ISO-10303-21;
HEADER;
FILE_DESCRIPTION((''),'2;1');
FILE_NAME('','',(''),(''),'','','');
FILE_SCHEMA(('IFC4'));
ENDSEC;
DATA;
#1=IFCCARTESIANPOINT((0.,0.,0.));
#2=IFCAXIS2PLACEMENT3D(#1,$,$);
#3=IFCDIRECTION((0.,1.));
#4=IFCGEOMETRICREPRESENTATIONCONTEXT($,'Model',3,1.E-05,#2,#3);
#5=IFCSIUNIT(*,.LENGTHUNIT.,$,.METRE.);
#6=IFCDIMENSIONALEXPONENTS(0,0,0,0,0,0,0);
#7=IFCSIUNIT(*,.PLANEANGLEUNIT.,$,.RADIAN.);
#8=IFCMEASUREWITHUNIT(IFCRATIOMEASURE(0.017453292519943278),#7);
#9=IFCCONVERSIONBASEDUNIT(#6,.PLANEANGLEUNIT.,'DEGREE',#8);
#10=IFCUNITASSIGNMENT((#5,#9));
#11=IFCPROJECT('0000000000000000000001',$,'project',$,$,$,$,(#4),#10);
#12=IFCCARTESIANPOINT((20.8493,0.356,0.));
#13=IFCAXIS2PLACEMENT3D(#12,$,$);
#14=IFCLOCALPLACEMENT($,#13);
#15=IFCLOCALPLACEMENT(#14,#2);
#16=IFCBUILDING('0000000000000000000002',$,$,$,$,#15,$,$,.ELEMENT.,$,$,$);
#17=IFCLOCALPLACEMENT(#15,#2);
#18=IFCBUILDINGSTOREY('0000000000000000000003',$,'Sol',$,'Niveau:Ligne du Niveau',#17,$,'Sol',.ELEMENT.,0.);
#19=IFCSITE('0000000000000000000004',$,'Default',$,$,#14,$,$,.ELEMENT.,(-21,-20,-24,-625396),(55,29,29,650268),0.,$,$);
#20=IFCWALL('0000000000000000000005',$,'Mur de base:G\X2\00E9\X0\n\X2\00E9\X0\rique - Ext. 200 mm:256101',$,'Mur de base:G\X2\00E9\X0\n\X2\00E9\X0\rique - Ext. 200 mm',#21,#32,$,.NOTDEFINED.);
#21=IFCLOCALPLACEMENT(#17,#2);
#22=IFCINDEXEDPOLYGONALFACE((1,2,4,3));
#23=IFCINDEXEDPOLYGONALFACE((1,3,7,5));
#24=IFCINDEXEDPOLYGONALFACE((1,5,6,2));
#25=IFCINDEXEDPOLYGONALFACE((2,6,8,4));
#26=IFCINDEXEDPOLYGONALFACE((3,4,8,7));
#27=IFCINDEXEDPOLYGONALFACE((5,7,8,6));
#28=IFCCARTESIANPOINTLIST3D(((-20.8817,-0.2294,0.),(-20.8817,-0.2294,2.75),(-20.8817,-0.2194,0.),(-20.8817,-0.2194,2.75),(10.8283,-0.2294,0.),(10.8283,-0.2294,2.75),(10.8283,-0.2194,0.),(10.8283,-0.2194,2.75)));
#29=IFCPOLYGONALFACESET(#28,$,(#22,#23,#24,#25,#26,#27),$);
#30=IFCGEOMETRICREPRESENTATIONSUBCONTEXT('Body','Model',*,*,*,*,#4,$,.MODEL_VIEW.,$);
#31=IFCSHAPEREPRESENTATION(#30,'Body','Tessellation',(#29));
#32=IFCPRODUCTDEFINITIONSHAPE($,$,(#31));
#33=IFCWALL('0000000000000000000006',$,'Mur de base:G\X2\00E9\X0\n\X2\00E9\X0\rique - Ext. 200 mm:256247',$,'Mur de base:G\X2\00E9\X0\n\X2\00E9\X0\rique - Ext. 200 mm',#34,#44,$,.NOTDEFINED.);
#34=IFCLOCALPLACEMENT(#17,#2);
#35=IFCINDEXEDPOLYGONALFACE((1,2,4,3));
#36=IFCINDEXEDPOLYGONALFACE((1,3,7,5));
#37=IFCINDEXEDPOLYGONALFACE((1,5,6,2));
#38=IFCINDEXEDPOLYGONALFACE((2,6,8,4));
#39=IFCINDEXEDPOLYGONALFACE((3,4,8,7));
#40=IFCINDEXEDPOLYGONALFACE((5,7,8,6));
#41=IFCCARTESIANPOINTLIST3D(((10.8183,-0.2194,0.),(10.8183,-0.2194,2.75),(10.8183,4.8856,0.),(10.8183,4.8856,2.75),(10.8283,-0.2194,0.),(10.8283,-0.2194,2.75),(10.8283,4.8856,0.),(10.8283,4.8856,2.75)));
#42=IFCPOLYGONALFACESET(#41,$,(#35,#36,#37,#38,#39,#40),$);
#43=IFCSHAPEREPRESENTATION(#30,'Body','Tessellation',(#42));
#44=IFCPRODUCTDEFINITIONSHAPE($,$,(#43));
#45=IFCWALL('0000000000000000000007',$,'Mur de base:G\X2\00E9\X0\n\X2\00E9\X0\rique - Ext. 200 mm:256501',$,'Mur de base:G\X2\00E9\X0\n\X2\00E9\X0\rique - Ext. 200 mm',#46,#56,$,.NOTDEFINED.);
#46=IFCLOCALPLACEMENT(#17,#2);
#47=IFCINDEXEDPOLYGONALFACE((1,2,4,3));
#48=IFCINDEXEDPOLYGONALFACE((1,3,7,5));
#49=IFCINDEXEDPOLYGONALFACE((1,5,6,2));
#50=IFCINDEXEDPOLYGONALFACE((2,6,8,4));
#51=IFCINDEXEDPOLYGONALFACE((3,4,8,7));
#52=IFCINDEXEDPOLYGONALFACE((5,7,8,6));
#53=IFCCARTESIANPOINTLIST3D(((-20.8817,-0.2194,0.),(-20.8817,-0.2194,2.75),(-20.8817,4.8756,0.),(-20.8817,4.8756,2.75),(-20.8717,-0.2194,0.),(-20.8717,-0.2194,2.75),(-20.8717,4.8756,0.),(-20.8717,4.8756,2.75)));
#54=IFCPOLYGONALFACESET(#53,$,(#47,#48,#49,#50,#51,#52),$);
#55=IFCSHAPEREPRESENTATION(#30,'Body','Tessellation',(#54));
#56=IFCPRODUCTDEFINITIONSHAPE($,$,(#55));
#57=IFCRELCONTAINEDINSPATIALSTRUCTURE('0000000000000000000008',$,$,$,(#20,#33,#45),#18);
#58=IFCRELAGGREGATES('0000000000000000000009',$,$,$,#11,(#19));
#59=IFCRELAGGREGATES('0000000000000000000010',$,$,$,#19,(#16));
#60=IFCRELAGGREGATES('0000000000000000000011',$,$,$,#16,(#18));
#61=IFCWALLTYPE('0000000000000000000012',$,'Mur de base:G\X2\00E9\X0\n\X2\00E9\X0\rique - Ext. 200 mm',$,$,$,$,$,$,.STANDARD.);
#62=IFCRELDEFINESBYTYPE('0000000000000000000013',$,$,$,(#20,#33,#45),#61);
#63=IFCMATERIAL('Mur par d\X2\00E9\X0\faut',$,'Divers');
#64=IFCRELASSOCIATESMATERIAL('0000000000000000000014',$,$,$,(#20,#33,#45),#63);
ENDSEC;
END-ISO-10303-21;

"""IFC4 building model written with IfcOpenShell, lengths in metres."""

from ifc_helpers import new_model, entity, si_unit, converted_unit, direction, frame, origin, place, context, subcontext, project, spatial, indexed_curve, outline, extrude, material, type_object, element, save


model = new_model("IFC4")

# Units and contexts
model_context = context("Model", 3, precision=1e-05, world=origin(), true_north=direction((0.0, 1.0)))
body_context = subcontext(model_context, "Body", "Model", "MODEL_VIEW")
ifc_project = project(units=[si_unit("LENGTHUNIT", "METRE"), converted_unit("PLANEANGLEUNIT", "DEGREE", entity("IfcRatioMeasure", 0.017453292519943278), si_unit("PLANEANGLEUNIT", "RADIAN"), dimensions=[0, 0, 0, 0, 0, 0, 0])], contexts=[model_context])

# Site, building, storey
site_placement = place(None, frame((20.8493, 0.356, 0.0)))
site = spatial("IfcSite", under=ifc_project, at=site_placement, Name="Default", CompositionType="ELEMENT", RefLatitude=(-21, -20, -24, -625396), RefLongitude=(55, 29, 29, 650268), RefElevation=0.0)
building_placement = place(site_placement, origin())
building = spatial("IfcBuilding", under=site, at=building_placement, CompositionType="ELEMENT")
storey_placement = place(building_placement, origin())
storey = spatial("IfcBuildingStorey", under=building, at=storey_placement, Name="Sol", ObjectType="Niveau:Ligne du Niveau", LongName="Sol", CompositionType="ELEMENT", Elevation=0.0)

# Walls
ifc_material = material(Name="Mur par défaut", Category="Divers")
wall_type = type_object("IfcWallType", Name="Mur de base:Générique - Ext. 200 mm", PredefinedType="STANDARD")
wall_1_placement = place(storey_placement, frame((-20.8817, -0.2244, 0.0)))
element("IfcWall", 1, at=wall_1_placement, inside=storey, type_object=wall_type, material=ifc_material, Name="Mur de base:Générique - Ext. 200 mm:256101", ObjectType="Mur de base:Générique - Ext. 200 mm", PredefinedType="NOTDEFINED", context=body_context, shape_type="SweptSolid", body=[
    extrude(outline(indexed_curve([(31.71, 0.005), (0.0, 0.005), (0.0, -0.005), (31.71, -0.005), (31.71, 0.005)], self_intersect=False)), origin(), (0.0, 0.0, 1.0), 2.75),
])
wall_2_placement = place(storey_placement, frame((10.8233, -0.2194, 0.0), z_axis=(0.0, 0.0, 1.0), x_axis=(0.0, 1.0, 0.0)))
element("IfcWall", 2, at=wall_2_placement, inside=storey, type_object=wall_type, material=ifc_material, Name="Mur de base:Générique - Ext. 200 mm:256247", ObjectType="Mur de base:Générique - Ext. 200 mm", PredefinedType="NOTDEFINED", context=body_context, shape_type="SweptSolid", body=[
    extrude(outline(indexed_curve([(5.105, 0.005), (0.0, 0.005), (0.0, -0.005), (5.105, -0.005), (5.105, 0.005)], self_intersect=False)), origin(), (0.0, 0.0, 1.0), 2.75),
])
wall_3_placement = place(storey_placement, frame((-20.8767, 4.8756, 0.0), z_axis=(0.0, 0.0, 1.0), x_axis=(0.0, -1.0, 0.0)))
element("IfcWall", 3, at=wall_3_placement, inside=storey, type_object=wall_type, material=ifc_material, Name="Mur de base:Générique - Ext. 200 mm:256501", ObjectType="Mur de base:Générique - Ext. 200 mm", PredefinedType="NOTDEFINED", context=body_context, shape_type="SweptSolid", body=[
    extrude(outline(indexed_curve([(5.095, 0.005), (0.0, 0.005), (0.0, -0.005), (5.095, -0.005), (5.095, 0.005)], self_intersect=False)), origin(), (0.0, 0.0, 1.0), 2.75),
])

save(model, "model.ifc")
